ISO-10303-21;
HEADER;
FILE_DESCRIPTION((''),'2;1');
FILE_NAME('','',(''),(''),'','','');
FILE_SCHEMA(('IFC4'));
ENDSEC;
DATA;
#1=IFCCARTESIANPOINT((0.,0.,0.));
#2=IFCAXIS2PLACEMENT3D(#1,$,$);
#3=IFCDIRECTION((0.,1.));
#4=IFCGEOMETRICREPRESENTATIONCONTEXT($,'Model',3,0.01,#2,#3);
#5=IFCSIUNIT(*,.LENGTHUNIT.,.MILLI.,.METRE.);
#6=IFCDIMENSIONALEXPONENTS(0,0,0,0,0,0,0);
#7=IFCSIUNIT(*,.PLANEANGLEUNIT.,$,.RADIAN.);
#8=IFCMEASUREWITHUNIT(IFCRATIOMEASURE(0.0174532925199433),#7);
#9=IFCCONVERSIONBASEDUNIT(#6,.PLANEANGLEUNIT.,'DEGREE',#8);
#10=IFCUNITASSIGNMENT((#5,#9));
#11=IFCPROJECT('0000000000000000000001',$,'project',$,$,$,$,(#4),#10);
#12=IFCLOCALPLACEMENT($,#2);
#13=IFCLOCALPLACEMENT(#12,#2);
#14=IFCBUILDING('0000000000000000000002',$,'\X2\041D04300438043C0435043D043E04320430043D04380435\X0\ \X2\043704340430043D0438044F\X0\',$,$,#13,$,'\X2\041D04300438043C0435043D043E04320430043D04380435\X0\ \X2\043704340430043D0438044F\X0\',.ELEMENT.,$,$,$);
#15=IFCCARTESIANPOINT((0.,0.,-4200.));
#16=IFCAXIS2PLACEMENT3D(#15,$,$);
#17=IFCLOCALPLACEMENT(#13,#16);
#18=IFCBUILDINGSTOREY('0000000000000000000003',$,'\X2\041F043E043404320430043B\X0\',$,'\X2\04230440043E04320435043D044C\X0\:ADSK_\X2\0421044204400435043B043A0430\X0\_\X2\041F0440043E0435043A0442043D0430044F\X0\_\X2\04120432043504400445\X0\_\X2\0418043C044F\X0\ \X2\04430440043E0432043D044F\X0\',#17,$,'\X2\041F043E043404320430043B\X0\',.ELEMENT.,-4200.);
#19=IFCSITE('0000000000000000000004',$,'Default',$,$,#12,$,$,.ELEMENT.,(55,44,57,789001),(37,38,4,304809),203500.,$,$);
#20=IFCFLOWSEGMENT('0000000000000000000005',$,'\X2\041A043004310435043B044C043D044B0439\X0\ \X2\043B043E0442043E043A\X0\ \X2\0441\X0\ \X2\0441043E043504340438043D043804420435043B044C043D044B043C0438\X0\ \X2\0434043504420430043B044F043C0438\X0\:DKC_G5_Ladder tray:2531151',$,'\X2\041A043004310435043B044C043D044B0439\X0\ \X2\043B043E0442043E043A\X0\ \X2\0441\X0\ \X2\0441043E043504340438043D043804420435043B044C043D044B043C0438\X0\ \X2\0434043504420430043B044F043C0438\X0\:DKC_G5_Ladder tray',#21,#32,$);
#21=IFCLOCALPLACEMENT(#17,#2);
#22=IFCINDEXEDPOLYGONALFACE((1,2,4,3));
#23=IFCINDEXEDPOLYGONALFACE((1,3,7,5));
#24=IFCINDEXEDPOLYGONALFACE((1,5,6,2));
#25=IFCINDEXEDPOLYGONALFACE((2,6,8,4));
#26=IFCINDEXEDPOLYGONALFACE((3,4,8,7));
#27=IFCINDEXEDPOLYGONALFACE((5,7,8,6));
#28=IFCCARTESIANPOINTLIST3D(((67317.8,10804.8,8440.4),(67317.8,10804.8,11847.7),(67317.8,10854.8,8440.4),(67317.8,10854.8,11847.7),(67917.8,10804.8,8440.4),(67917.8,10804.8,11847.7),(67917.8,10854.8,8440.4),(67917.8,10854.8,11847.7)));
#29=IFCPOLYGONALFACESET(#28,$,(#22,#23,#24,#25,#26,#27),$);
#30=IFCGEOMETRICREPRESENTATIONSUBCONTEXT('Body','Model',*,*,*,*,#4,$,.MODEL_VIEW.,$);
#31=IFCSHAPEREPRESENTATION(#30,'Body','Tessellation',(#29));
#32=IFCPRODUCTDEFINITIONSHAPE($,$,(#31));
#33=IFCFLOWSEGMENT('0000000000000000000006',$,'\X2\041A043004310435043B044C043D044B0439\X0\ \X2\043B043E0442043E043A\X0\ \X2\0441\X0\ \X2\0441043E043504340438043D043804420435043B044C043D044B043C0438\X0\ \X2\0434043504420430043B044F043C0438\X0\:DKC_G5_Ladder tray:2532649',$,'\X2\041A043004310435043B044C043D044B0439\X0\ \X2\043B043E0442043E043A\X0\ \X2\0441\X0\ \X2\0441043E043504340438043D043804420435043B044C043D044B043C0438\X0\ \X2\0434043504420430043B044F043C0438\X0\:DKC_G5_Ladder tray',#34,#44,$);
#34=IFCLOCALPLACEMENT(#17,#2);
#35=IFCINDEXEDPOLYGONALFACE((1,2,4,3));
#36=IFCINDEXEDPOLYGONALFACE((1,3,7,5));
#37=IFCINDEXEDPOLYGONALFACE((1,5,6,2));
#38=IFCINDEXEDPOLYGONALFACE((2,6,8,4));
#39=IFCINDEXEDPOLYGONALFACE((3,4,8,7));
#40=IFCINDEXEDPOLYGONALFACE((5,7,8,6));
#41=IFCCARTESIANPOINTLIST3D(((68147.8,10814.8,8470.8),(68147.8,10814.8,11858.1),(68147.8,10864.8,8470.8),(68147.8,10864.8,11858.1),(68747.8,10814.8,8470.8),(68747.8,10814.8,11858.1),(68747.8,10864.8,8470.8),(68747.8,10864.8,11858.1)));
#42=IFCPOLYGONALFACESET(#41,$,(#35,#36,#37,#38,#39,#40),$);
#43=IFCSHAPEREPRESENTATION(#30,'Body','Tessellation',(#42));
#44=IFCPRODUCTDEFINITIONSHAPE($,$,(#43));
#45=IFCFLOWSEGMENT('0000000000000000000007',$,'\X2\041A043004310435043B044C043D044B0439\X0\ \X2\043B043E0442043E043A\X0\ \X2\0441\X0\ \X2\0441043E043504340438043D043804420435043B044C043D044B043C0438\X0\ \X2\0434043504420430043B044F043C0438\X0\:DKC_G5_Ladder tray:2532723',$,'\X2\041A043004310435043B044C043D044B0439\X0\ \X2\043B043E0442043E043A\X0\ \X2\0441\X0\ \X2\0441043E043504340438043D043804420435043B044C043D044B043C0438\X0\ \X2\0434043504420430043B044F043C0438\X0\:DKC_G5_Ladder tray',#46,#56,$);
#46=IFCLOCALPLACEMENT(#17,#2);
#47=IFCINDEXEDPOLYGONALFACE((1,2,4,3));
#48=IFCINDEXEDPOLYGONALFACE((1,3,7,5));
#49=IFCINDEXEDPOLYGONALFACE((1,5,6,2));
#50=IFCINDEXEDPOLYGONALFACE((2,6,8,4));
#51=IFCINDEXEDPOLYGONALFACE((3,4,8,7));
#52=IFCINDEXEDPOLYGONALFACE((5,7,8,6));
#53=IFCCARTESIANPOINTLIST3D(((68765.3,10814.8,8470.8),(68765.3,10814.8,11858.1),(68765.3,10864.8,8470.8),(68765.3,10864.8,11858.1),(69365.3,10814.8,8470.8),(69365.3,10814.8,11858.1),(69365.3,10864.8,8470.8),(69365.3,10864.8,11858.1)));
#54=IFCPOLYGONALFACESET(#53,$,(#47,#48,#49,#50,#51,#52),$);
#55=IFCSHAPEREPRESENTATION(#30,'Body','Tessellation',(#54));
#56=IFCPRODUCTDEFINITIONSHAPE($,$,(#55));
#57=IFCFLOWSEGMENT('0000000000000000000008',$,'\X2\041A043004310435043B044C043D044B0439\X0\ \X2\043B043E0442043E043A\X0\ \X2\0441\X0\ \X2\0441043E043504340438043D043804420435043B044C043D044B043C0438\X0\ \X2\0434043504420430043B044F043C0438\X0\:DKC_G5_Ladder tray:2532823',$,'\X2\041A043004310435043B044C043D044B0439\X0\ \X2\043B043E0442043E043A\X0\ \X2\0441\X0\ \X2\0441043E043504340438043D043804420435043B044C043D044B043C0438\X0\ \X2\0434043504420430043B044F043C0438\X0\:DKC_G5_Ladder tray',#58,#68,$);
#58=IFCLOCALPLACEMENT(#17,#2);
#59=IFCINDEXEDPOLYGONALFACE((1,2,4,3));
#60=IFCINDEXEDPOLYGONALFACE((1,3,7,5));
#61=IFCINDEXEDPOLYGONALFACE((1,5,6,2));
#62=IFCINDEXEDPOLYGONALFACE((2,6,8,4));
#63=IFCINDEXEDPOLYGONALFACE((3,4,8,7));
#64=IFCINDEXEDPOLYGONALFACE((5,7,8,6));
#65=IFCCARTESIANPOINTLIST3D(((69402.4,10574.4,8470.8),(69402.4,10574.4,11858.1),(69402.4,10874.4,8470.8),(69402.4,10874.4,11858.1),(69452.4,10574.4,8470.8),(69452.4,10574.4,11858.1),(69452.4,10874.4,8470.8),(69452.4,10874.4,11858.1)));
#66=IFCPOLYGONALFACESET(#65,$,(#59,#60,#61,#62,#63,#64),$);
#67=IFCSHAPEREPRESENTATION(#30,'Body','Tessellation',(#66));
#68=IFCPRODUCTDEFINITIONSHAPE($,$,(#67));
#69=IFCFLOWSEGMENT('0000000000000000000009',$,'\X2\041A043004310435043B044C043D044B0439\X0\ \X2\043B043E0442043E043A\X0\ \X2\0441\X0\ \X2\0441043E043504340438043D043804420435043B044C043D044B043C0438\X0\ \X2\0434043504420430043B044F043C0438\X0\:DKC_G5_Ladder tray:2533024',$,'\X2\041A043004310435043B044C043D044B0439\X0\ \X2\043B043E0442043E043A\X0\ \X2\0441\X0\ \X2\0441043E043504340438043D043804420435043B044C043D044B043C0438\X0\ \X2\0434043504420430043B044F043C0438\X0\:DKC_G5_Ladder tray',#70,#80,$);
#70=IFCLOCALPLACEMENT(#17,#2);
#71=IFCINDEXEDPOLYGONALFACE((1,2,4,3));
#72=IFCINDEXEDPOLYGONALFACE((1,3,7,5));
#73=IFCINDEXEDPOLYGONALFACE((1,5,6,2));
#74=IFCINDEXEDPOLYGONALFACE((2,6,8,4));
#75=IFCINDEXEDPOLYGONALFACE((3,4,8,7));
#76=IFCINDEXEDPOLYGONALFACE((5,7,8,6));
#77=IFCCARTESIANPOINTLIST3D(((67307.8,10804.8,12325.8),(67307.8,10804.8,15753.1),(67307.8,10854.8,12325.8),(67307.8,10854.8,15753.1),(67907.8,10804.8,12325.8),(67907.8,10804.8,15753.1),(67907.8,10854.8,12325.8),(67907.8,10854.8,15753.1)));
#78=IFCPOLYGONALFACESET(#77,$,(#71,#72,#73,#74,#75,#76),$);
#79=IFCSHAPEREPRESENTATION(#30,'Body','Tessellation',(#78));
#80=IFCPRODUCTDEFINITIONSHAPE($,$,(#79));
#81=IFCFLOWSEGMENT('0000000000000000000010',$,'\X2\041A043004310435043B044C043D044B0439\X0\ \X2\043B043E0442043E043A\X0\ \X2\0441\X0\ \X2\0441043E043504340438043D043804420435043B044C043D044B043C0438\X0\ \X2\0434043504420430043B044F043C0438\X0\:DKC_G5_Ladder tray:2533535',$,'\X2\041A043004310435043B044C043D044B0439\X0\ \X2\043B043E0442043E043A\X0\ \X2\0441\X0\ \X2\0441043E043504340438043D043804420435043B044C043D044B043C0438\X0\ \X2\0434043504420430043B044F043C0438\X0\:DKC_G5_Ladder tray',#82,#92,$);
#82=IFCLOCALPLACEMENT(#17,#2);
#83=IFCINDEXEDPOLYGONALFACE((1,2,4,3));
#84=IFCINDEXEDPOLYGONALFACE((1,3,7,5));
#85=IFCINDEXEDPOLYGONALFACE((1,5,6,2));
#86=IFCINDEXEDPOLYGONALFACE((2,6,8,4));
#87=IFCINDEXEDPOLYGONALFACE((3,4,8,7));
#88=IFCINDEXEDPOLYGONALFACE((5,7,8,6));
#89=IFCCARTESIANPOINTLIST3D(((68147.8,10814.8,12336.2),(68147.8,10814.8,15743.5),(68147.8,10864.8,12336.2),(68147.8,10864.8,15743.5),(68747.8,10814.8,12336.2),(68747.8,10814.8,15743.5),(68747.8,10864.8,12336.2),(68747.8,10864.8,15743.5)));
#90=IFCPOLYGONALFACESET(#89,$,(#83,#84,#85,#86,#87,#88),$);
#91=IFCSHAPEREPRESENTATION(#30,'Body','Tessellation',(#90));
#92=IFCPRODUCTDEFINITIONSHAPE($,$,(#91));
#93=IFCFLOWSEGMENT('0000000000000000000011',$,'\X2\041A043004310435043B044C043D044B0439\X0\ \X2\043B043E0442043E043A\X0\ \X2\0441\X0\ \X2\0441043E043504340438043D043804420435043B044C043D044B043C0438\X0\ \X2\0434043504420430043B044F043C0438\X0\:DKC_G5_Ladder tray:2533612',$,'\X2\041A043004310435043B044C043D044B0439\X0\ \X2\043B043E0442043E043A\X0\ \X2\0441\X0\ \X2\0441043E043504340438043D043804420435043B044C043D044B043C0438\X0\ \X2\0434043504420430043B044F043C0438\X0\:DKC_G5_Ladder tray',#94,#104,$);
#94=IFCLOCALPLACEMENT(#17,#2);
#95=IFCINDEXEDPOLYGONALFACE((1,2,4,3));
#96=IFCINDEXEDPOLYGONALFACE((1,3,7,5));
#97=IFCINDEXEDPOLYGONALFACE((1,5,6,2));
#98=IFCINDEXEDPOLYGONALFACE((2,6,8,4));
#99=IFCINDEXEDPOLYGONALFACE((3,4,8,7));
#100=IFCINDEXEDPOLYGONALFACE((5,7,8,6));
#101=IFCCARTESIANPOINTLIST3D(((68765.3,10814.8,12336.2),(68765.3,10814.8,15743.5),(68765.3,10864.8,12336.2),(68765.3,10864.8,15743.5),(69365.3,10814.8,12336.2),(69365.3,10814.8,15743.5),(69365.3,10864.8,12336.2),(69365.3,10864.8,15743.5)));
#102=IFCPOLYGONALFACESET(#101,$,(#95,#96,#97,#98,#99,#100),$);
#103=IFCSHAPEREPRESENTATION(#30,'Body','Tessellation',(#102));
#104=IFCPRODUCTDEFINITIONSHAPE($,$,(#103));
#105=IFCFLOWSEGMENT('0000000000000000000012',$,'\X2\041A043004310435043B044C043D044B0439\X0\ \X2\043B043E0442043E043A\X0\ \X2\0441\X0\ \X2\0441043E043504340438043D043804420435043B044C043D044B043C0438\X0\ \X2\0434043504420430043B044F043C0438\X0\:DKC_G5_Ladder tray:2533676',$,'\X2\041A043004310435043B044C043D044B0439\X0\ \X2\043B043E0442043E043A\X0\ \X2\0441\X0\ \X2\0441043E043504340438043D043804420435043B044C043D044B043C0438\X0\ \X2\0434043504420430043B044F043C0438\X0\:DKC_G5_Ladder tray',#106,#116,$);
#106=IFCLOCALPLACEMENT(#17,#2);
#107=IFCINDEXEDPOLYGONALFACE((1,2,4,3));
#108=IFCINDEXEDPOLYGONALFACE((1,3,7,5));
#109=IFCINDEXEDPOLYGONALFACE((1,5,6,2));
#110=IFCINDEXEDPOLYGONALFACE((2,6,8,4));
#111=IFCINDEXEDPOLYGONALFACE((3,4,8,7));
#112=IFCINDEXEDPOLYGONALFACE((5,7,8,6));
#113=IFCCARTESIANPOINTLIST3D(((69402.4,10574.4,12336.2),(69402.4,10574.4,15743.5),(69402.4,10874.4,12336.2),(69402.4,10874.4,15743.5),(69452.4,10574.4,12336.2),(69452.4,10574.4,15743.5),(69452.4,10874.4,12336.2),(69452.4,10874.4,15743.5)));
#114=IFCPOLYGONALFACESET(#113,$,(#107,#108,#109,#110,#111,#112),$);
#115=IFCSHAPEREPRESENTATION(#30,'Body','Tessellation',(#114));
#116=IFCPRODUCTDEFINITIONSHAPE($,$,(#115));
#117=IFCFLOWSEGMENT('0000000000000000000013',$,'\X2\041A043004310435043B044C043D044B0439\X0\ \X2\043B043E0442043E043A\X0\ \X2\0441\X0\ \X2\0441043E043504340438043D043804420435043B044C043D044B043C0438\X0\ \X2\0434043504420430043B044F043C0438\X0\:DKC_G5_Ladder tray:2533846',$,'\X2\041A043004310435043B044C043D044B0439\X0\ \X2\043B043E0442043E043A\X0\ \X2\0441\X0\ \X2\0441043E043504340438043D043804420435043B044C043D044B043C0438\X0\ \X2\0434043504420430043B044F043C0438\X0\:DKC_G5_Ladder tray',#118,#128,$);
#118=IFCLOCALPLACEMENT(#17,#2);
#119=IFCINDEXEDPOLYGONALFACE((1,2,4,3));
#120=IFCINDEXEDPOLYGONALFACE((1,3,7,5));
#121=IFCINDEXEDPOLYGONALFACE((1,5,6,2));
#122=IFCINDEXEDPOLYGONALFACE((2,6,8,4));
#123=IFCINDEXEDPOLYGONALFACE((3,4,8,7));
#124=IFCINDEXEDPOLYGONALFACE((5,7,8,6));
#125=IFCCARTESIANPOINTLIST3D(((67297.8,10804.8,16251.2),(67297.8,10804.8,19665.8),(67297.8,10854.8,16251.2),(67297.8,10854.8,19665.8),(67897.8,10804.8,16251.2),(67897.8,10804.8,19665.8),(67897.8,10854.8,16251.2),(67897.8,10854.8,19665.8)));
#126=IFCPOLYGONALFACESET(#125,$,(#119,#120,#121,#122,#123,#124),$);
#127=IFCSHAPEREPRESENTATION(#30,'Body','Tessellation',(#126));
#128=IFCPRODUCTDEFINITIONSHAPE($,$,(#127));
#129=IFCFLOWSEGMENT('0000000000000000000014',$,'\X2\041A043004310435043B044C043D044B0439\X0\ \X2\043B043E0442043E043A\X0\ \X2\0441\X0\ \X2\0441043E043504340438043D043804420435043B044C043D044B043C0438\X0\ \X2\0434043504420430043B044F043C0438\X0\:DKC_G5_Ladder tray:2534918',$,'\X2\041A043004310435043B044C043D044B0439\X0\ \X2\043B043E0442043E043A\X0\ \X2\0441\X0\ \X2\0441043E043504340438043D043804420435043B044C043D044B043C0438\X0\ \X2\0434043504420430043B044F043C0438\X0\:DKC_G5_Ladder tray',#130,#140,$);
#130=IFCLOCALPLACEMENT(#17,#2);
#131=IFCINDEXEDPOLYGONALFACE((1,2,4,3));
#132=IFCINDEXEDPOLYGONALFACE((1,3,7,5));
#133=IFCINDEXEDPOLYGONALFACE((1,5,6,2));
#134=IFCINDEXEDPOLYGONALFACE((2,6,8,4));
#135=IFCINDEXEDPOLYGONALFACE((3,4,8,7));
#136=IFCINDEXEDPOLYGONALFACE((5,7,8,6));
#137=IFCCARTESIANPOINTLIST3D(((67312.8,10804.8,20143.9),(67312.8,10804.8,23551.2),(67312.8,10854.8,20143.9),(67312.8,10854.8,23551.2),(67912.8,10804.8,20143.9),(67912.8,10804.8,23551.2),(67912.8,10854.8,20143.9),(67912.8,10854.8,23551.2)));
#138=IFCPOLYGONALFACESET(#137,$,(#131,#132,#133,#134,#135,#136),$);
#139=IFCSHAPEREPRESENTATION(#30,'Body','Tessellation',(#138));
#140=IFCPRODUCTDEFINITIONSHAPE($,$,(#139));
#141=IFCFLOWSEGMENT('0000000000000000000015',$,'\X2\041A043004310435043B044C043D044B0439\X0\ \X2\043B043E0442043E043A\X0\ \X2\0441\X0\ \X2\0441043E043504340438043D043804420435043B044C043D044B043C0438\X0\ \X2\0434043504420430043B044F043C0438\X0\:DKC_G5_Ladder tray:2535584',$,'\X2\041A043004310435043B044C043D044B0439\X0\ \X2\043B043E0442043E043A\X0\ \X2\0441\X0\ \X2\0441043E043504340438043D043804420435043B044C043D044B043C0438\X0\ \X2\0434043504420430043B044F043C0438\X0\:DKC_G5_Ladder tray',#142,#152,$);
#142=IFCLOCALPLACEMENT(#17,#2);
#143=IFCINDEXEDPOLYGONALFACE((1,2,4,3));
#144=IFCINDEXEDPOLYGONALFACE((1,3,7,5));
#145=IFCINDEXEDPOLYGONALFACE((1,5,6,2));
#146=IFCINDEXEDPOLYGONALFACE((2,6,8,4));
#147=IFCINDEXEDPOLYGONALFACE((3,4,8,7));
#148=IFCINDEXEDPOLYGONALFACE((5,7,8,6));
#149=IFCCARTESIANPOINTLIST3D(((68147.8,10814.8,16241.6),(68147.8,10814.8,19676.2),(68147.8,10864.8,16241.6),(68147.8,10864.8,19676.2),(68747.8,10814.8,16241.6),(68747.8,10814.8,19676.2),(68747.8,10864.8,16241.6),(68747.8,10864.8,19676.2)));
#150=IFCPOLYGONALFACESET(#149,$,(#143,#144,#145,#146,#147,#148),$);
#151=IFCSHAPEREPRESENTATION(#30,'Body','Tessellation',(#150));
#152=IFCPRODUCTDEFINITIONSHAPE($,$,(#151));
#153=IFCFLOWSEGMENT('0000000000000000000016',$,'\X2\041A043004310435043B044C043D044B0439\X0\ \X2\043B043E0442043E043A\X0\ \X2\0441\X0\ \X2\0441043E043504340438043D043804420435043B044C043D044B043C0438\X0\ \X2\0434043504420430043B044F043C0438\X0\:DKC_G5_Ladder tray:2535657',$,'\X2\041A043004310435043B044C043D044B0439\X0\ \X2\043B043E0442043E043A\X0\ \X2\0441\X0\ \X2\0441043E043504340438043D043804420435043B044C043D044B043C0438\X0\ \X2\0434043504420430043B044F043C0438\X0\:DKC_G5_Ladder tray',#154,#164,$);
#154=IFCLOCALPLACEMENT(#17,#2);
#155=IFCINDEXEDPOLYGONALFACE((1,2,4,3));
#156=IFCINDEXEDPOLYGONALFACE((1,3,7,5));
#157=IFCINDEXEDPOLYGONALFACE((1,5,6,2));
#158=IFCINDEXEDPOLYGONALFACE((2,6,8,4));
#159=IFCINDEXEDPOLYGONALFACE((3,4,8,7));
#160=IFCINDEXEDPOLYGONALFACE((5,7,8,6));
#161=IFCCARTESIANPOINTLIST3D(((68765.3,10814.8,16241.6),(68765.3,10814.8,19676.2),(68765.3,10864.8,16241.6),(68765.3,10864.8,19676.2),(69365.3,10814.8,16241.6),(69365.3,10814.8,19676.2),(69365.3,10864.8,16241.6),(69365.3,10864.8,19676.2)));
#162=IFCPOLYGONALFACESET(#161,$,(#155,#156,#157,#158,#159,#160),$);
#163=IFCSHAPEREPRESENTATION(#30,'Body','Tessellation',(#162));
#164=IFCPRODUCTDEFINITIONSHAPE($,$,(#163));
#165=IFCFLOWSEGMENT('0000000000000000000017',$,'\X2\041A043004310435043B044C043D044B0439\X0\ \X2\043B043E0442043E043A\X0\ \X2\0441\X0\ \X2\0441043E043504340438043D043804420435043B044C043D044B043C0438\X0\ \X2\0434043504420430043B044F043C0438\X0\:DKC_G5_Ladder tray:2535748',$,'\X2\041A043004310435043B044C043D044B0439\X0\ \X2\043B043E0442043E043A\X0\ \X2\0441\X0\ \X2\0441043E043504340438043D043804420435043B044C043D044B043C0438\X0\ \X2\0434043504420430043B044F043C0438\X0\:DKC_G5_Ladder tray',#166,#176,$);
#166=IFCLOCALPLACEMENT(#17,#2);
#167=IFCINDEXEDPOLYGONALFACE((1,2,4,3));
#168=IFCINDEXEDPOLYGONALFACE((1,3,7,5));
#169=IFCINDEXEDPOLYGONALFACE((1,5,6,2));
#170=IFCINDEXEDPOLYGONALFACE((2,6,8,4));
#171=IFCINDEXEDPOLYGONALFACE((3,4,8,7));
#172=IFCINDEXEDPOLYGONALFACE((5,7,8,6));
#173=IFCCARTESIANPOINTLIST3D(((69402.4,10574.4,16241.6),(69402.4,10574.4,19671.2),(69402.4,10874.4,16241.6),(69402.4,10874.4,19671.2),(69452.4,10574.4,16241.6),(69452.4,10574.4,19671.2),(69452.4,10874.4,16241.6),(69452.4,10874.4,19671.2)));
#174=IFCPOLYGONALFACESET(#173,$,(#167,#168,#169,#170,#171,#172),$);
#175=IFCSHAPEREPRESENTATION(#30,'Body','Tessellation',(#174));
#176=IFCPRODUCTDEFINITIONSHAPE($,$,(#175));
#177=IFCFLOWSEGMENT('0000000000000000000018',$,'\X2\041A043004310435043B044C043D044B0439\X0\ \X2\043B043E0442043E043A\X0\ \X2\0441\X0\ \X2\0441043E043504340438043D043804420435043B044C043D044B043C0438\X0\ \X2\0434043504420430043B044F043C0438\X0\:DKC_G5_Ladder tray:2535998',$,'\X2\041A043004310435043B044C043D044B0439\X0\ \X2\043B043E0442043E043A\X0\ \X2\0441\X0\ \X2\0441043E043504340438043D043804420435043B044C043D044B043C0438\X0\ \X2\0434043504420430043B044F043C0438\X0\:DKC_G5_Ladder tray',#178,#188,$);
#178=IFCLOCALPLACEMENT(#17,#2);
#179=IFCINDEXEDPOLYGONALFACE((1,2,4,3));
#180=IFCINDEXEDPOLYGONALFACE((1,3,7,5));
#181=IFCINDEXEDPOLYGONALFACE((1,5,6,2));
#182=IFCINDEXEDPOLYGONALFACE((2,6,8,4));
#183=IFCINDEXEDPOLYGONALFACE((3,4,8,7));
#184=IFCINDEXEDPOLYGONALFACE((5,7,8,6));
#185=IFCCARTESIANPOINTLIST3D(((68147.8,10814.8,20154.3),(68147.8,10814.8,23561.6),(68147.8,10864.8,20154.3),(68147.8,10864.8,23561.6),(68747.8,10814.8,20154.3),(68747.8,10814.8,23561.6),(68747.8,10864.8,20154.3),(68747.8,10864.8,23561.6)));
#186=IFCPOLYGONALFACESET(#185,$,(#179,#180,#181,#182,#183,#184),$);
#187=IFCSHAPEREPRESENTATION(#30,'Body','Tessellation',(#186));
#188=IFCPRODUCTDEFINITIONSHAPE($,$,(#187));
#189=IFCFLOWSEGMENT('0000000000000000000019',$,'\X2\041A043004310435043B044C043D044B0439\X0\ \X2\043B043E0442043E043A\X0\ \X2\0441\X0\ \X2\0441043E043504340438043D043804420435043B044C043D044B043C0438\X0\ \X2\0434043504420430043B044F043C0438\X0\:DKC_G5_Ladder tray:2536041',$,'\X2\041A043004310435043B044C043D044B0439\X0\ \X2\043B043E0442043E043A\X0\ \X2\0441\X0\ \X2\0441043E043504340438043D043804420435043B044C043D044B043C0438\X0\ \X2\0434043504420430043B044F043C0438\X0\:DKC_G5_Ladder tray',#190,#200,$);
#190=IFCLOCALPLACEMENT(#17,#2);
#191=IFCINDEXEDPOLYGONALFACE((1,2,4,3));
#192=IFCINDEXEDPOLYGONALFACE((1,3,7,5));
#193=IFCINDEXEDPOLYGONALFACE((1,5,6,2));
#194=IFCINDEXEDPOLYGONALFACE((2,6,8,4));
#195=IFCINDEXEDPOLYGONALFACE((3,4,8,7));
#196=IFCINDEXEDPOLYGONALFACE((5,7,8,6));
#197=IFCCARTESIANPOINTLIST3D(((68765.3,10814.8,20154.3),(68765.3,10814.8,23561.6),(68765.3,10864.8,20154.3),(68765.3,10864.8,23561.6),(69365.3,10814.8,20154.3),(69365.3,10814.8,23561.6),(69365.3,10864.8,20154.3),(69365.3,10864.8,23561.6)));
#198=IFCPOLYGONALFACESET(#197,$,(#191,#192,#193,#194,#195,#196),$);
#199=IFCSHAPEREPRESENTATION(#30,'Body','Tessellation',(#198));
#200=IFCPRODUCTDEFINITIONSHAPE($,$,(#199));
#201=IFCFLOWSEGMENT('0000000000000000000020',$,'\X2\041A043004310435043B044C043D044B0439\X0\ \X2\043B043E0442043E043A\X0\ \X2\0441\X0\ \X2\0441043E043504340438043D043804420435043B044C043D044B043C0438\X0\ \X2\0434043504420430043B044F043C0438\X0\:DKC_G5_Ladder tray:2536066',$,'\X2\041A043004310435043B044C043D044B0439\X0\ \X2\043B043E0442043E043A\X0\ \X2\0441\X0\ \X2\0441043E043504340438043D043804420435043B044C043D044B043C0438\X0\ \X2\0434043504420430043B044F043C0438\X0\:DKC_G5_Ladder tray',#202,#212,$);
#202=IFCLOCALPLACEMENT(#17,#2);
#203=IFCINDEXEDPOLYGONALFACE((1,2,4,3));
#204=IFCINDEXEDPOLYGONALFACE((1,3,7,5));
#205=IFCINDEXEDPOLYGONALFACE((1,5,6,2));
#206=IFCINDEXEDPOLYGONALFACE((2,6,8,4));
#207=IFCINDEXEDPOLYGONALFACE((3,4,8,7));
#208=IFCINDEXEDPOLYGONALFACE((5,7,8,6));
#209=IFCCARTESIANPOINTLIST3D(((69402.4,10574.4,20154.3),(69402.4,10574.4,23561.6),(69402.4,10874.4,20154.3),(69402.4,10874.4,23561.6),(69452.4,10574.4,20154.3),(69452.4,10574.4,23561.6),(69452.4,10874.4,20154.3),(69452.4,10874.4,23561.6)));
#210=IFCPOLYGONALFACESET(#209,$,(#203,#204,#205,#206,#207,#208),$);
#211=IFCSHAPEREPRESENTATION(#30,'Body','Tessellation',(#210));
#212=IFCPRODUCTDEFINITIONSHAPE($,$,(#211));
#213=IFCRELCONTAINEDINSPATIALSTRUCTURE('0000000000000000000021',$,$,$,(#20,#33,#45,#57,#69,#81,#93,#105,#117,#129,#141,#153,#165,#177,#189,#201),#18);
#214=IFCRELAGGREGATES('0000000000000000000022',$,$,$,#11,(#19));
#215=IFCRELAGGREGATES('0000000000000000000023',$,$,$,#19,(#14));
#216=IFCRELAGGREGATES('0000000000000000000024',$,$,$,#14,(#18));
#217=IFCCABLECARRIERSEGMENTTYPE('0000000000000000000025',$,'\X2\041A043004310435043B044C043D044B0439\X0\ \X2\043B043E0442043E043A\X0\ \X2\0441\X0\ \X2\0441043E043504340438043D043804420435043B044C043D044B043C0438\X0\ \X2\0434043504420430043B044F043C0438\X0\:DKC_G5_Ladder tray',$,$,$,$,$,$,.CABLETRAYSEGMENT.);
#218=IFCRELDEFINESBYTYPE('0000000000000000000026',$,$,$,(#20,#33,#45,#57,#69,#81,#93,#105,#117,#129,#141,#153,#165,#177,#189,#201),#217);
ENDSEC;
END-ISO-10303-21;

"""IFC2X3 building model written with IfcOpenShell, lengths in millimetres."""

from ifc_helpers import new_model, entity, si_unit, converted_unit, direction, frame, origin, origin_2d_with_axis, place, context, subcontext, project, spatial, rectangle, extrude, type_object, element, save


model = new_model("IFC2X3")

# Units and contexts
model_context = context("Model", 3, precision=0.01, world=origin(), true_north=direction((0.0, 1.0)))
body_context = subcontext(model_context, "Body", "Model", "MODEL_VIEW")
ifc_project = project(units=[si_unit("LENGTHUNIT", "METRE", prefix="MILLI"), converted_unit("PLANEANGLEUNIT", "DEGREE", entity("IfcRatioMeasure", 0.0174532925199433), si_unit("PLANEANGLEUNIT", "RADIAN"), dimensions=[0, 0, 0, 0, 0, 0, 0])], contexts=[model_context])

# Site, building, storey
site_placement = place(None, origin())
site = spatial("IfcSite", under=ifc_project, at=site_placement, Name="Default", CompositionType="ELEMENT", RefLatitude=(55, 44, 57, 789001), RefLongitude=(37, 38, 4, 304809), RefElevation=203500.0)
building_placement = place(site_placement, origin())
building = spatial("IfcBuilding", under=site, at=building_placement, Name="Наименование здания", LongName="Наименование здания", CompositionType="ELEMENT")
storey_placement = place(building_placement, frame((0.0, 0.0, -4200.0)))
storey = spatial("IfcBuildingStorey", under=building, at=storey_placement, Name="Подвал", ObjectType="Уровень:ADSK_Стрелка_Проектная_Вверх_Имя уровня", LongName="Подвал", CompositionType="ELEMENT", Elevation=-4200.0)

# Flow segments
cable_carrier_segment_type = type_object("IfcCableCarrierSegmentType", Name="Кабельный лоток с соединительными деталями:DKC_G5_Ladder tray", PredefinedType="CABLETRAYSEGMENT")
flow_segment_1_placement = place(storey_placement, frame((67317.8, 10804.8, 8440.4)))
element("IfcFlowSegment", 1, at=flow_segment_1_placement, inside=storey, type_object=cable_carrier_segment_type, Name="Кабельный лоток с соединительными деталями:DKC_G5_Ladder tray:2531151", ObjectType="Кабельный лоток с соединительными деталями:DKC_G5_Ladder tray", context=body_context, shape_type="SweptSolid", body=[
    extrude(rectangle(XDim=50.0, YDim=600.0, at=origin_2d_with_axis()), frame((300.0, 25.0, 0.0), z_axis=(0.0, 0.0, 1.0), x_axis=(0.0, 1.0, 0.0)), (0.0, 0.0, 1.0), 3407.3),
])
for number, where, name in (
    (2, (68147.8, 10814.8, 8470.8), "Кабельный лоток с соединительными деталями:DKC_G5_Ladder tray:2532649"),
    (3, (68765.3, 10814.8, 8470.8), "Кабельный лоток с соединительными деталями:DKC_G5_Ladder tray:2532723"),
):
    element("IfcFlowSegment", number, at=place(storey_placement, frame(where)), inside=storey, type_object=cable_carrier_segment_type, Name=name, ObjectType="Кабельный лоток с соединительными деталями:DKC_G5_Ladder tray", context=body_context, shape_type="SweptSolid", body=[
        extrude(rectangle(XDim=600.0, YDim=50.0, at=origin_2d_with_axis()), frame((300.0, 25.0, 0.0)), (0.0, 0.0, 1.0), 3387.3),
    ])
flow_segment_2_placement = place(storey_placement, frame((69402.4, 10574.4, 8470.8)))
element("IfcFlowSegment", 4, at=flow_segment_2_placement, inside=storey, type_object=cable_carrier_segment_type, Name="Кабельный лоток с соединительными деталями:DKC_G5_Ladder tray:2532823", ObjectType="Кабельный лоток с соединительными деталями:DKC_G5_Ladder tray", context=body_context, shape_type="SweptSolid", body=[
    extrude(rectangle(XDim=300.0, YDim=50.0, at=origin_2d_with_axis()), frame((25.0, 150.0, 0.0), z_axis=(0.0, 0.0, 1.0), x_axis=(0.0, -1.0, 0.0)), (0.0, 0.0, 1.0), 3387.3),
])
flow_segment_3_placement = place(storey_placement, frame((67307.8, 10804.8, 12325.8)))
element("IfcFlowSegment", 5, at=flow_segment_3_placement, inside=storey, type_object=cable_carrier_segment_type, Name="Кабельный лоток с соединительными деталями:DKC_G5_Ladder tray:2533024", ObjectType="Кабельный лоток с соединительными деталями:DKC_G5_Ladder tray", context=body_context, shape_type="SweptSolid", body=[
    extrude(rectangle(XDim=50.0, YDim=600.0, at=origin_2d_with_axis()), frame((300.0, 25.0, 0.0), z_axis=(0.0, 0.0, 1.0), x_axis=(0.0, 1.0, 0.0)), (0.0, 0.0, 1.0), 3427.3),
])
flow_segment_4_placement = place(storey_placement, frame((68147.8, 10814.8, 12336.2)))
element("IfcFlowSegment", 6, at=flow_segment_4_placement, inside=storey, type_object=cable_carrier_segment_type, Name="Кабельный лоток с соединительными деталями:DKC_G5_Ladder tray:2533535", ObjectType="Кабельный лоток с соединительными деталями:DKC_G5_Ladder tray", context=body_context, shape_type="SweptSolid", body=[
    extrude(rectangle(XDim=600.0, YDim=50.0, at=origin_2d_with_axis()), frame((300.0, 25.0, 0.0)), (0.0, 0.0, 1.0), 3407.3),
])
flow_segment_5_placement = place(storey_placement, frame((68765.3, 10814.8, 12336.2)))
element("IfcFlowSegment", 7, at=flow_segment_5_placement, inside=storey, type_object=cable_carrier_segment_type, Name="Кабельный лоток с соединительными деталями:DKC_G5_Ladder tray:2533612", ObjectType="Кабельный лоток с соединительными деталями:DKC_G5_Ladder tray", context=body_context, shape_type="SweptSolid", body=[
    extrude(rectangle(XDim=600.0, YDim=50.0, at=origin_2d_with_axis()), frame((300.0, 25.0, 0.0)), (0.0, 0.0, 1.0), 3407.3),
])
flow_segment_6_placement = place(storey_placement, frame((69402.4, 10574.4, 12336.2)))
element("IfcFlowSegment", 8, at=flow_segment_6_placement, inside=storey, type_object=cable_carrier_segment_type, Name="Кабельный лоток с соединительными деталями:DKC_G5_Ladder tray:2533676", ObjectType="Кабельный лоток с соединительными деталями:DKC_G5_Ladder tray", context=body_context, shape_type="SweptSolid", body=[
    extrude(rectangle(XDim=300.0, YDim=50.0, at=origin_2d_with_axis()), frame((25.0, 150.0, 0.0), z_axis=(0.0, 0.0, 1.0), x_axis=(0.0, -1.0, 0.0)), (0.0, 0.0, 1.0), 3407.3),
])
flow_segment_7_placement = place(storey_placement, frame((67297.8, 10804.8, 16251.2)))
element("IfcFlowSegment", 9, at=flow_segment_7_placement, inside=storey, type_object=cable_carrier_segment_type, Name="Кабельный лоток с соединительными деталями:DKC_G5_Ladder tray:2533846", ObjectType="Кабельный лоток с соединительными деталями:DKC_G5_Ladder tray", context=body_context, shape_type="SweptSolid", body=[
    extrude(rectangle(XDim=50.0, YDim=600.0, at=origin_2d_with_axis()), frame((300.0, 25.0, 0.0), z_axis=(0.0, 0.0, 1.0), x_axis=(0.0, 1.0, 0.0)), (0.0, 0.0, 1.0), 3414.6),
])
flow_segment_8_placement = place(storey_placement, frame((67312.8, 10804.8, 20143.9)))
element("IfcFlowSegment", 10, at=flow_segment_8_placement, inside=storey, type_object=cable_carrier_segment_type, Name="Кабельный лоток с соединительными деталями:DKC_G5_Ladder tray:2534918", ObjectType="Кабельный лоток с соединительными деталями:DKC_G5_Ladder tray", context=body_context, shape_type="SweptSolid", body=[
    extrude(rectangle(XDim=50.0, YDim=600.0, at=origin_2d_with_axis()), frame((300.0, 25.0, 0.0), z_axis=(0.0, 0.0, 1.0), x_axis=(0.0, 1.0, 0.0)), (0.0, 0.0, 1.0), 3407.3),
])
for number, where, name in (
    (11, (68147.8, 10814.8, 16241.6), "Кабельный лоток с соединительными деталями:DKC_G5_Ladder tray:2535584"),
    (12, (68765.3, 10814.8, 16241.6), "Кабельный лоток с соединительными деталями:DKC_G5_Ladder tray:2535657"),
):
    element("IfcFlowSegment", number, at=place(storey_placement, frame(where)), inside=storey, type_object=cable_carrier_segment_type, Name=name, ObjectType="Кабельный лоток с соединительными деталями:DKC_G5_Ladder tray", context=body_context, shape_type="SweptSolid", body=[
        extrude(rectangle(XDim=600.0, YDim=50.0, at=origin_2d_with_axis()), frame((300.0, 25.0, 0.0)), (0.0, 0.0, 1.0), 3434.6),
    ])
flow_segment_9_placement = place(storey_placement, frame((69402.4, 10574.4, 16241.6)))
element("IfcFlowSegment", 13, at=flow_segment_9_placement, inside=storey, type_object=cable_carrier_segment_type, Name="Кабельный лоток с соединительными деталями:DKC_G5_Ladder tray:2535748", ObjectType="Кабельный лоток с соединительными деталями:DKC_G5_Ladder tray", context=body_context, shape_type="SweptSolid", body=[
    extrude(rectangle(XDim=300.0, YDim=50.0, at=origin_2d_with_axis()), frame((25.0, 150.0, 0.0), z_axis=(0.0, 0.0, 1.0), x_axis=(0.0, -1.0, 0.0)), (0.0, 0.0, 1.0), 3429.6),
])
for number, where, name in (
    (14, (68147.8, 10814.8, 20154.3), "Кабельный лоток с соединительными деталями:DKC_G5_Ladder tray:2535998"),
    (15, (68765.3, 10814.8, 20154.3), "Кабельный лоток с соединительными деталями:DKC_G5_Ladder tray:2536041"),
):
    element("IfcFlowSegment", number, at=place(storey_placement, frame(where)), inside=storey, type_object=cable_carrier_segment_type, Name=name, ObjectType="Кабельный лоток с соединительными деталями:DKC_G5_Ladder tray", context=body_context, shape_type="SweptSolid", body=[
        extrude(rectangle(XDim=600.0, YDim=50.0, at=origin_2d_with_axis()), frame((300.0, 25.0, 0.0)), (0.0, 0.0, 1.0), 3407.3),
    ])
flow_segment_10_placement = place(storey_placement, frame((69402.4, 10574.4, 20154.3)))
element("IfcFlowSegment", 16, at=flow_segment_10_placement, inside=storey, type_object=cable_carrier_segment_type, Name="Кабельный лоток с соединительными деталями:DKC_G5_Ladder tray:2536066", ObjectType="Кабельный лоток с соединительными деталями:DKC_G5_Ladder tray", context=body_context, shape_type="SweptSolid", body=[
    extrude(rectangle(XDim=300.0, YDim=50.0, at=origin_2d_with_axis()), frame((25.0, 150.0, 0.0), z_axis=(0.0, 0.0, 1.0), x_axis=(0.0, -1.0, 0.0)), (0.0, 0.0, 1.0), 3407.3),
])

save(model, "model.ifc")
